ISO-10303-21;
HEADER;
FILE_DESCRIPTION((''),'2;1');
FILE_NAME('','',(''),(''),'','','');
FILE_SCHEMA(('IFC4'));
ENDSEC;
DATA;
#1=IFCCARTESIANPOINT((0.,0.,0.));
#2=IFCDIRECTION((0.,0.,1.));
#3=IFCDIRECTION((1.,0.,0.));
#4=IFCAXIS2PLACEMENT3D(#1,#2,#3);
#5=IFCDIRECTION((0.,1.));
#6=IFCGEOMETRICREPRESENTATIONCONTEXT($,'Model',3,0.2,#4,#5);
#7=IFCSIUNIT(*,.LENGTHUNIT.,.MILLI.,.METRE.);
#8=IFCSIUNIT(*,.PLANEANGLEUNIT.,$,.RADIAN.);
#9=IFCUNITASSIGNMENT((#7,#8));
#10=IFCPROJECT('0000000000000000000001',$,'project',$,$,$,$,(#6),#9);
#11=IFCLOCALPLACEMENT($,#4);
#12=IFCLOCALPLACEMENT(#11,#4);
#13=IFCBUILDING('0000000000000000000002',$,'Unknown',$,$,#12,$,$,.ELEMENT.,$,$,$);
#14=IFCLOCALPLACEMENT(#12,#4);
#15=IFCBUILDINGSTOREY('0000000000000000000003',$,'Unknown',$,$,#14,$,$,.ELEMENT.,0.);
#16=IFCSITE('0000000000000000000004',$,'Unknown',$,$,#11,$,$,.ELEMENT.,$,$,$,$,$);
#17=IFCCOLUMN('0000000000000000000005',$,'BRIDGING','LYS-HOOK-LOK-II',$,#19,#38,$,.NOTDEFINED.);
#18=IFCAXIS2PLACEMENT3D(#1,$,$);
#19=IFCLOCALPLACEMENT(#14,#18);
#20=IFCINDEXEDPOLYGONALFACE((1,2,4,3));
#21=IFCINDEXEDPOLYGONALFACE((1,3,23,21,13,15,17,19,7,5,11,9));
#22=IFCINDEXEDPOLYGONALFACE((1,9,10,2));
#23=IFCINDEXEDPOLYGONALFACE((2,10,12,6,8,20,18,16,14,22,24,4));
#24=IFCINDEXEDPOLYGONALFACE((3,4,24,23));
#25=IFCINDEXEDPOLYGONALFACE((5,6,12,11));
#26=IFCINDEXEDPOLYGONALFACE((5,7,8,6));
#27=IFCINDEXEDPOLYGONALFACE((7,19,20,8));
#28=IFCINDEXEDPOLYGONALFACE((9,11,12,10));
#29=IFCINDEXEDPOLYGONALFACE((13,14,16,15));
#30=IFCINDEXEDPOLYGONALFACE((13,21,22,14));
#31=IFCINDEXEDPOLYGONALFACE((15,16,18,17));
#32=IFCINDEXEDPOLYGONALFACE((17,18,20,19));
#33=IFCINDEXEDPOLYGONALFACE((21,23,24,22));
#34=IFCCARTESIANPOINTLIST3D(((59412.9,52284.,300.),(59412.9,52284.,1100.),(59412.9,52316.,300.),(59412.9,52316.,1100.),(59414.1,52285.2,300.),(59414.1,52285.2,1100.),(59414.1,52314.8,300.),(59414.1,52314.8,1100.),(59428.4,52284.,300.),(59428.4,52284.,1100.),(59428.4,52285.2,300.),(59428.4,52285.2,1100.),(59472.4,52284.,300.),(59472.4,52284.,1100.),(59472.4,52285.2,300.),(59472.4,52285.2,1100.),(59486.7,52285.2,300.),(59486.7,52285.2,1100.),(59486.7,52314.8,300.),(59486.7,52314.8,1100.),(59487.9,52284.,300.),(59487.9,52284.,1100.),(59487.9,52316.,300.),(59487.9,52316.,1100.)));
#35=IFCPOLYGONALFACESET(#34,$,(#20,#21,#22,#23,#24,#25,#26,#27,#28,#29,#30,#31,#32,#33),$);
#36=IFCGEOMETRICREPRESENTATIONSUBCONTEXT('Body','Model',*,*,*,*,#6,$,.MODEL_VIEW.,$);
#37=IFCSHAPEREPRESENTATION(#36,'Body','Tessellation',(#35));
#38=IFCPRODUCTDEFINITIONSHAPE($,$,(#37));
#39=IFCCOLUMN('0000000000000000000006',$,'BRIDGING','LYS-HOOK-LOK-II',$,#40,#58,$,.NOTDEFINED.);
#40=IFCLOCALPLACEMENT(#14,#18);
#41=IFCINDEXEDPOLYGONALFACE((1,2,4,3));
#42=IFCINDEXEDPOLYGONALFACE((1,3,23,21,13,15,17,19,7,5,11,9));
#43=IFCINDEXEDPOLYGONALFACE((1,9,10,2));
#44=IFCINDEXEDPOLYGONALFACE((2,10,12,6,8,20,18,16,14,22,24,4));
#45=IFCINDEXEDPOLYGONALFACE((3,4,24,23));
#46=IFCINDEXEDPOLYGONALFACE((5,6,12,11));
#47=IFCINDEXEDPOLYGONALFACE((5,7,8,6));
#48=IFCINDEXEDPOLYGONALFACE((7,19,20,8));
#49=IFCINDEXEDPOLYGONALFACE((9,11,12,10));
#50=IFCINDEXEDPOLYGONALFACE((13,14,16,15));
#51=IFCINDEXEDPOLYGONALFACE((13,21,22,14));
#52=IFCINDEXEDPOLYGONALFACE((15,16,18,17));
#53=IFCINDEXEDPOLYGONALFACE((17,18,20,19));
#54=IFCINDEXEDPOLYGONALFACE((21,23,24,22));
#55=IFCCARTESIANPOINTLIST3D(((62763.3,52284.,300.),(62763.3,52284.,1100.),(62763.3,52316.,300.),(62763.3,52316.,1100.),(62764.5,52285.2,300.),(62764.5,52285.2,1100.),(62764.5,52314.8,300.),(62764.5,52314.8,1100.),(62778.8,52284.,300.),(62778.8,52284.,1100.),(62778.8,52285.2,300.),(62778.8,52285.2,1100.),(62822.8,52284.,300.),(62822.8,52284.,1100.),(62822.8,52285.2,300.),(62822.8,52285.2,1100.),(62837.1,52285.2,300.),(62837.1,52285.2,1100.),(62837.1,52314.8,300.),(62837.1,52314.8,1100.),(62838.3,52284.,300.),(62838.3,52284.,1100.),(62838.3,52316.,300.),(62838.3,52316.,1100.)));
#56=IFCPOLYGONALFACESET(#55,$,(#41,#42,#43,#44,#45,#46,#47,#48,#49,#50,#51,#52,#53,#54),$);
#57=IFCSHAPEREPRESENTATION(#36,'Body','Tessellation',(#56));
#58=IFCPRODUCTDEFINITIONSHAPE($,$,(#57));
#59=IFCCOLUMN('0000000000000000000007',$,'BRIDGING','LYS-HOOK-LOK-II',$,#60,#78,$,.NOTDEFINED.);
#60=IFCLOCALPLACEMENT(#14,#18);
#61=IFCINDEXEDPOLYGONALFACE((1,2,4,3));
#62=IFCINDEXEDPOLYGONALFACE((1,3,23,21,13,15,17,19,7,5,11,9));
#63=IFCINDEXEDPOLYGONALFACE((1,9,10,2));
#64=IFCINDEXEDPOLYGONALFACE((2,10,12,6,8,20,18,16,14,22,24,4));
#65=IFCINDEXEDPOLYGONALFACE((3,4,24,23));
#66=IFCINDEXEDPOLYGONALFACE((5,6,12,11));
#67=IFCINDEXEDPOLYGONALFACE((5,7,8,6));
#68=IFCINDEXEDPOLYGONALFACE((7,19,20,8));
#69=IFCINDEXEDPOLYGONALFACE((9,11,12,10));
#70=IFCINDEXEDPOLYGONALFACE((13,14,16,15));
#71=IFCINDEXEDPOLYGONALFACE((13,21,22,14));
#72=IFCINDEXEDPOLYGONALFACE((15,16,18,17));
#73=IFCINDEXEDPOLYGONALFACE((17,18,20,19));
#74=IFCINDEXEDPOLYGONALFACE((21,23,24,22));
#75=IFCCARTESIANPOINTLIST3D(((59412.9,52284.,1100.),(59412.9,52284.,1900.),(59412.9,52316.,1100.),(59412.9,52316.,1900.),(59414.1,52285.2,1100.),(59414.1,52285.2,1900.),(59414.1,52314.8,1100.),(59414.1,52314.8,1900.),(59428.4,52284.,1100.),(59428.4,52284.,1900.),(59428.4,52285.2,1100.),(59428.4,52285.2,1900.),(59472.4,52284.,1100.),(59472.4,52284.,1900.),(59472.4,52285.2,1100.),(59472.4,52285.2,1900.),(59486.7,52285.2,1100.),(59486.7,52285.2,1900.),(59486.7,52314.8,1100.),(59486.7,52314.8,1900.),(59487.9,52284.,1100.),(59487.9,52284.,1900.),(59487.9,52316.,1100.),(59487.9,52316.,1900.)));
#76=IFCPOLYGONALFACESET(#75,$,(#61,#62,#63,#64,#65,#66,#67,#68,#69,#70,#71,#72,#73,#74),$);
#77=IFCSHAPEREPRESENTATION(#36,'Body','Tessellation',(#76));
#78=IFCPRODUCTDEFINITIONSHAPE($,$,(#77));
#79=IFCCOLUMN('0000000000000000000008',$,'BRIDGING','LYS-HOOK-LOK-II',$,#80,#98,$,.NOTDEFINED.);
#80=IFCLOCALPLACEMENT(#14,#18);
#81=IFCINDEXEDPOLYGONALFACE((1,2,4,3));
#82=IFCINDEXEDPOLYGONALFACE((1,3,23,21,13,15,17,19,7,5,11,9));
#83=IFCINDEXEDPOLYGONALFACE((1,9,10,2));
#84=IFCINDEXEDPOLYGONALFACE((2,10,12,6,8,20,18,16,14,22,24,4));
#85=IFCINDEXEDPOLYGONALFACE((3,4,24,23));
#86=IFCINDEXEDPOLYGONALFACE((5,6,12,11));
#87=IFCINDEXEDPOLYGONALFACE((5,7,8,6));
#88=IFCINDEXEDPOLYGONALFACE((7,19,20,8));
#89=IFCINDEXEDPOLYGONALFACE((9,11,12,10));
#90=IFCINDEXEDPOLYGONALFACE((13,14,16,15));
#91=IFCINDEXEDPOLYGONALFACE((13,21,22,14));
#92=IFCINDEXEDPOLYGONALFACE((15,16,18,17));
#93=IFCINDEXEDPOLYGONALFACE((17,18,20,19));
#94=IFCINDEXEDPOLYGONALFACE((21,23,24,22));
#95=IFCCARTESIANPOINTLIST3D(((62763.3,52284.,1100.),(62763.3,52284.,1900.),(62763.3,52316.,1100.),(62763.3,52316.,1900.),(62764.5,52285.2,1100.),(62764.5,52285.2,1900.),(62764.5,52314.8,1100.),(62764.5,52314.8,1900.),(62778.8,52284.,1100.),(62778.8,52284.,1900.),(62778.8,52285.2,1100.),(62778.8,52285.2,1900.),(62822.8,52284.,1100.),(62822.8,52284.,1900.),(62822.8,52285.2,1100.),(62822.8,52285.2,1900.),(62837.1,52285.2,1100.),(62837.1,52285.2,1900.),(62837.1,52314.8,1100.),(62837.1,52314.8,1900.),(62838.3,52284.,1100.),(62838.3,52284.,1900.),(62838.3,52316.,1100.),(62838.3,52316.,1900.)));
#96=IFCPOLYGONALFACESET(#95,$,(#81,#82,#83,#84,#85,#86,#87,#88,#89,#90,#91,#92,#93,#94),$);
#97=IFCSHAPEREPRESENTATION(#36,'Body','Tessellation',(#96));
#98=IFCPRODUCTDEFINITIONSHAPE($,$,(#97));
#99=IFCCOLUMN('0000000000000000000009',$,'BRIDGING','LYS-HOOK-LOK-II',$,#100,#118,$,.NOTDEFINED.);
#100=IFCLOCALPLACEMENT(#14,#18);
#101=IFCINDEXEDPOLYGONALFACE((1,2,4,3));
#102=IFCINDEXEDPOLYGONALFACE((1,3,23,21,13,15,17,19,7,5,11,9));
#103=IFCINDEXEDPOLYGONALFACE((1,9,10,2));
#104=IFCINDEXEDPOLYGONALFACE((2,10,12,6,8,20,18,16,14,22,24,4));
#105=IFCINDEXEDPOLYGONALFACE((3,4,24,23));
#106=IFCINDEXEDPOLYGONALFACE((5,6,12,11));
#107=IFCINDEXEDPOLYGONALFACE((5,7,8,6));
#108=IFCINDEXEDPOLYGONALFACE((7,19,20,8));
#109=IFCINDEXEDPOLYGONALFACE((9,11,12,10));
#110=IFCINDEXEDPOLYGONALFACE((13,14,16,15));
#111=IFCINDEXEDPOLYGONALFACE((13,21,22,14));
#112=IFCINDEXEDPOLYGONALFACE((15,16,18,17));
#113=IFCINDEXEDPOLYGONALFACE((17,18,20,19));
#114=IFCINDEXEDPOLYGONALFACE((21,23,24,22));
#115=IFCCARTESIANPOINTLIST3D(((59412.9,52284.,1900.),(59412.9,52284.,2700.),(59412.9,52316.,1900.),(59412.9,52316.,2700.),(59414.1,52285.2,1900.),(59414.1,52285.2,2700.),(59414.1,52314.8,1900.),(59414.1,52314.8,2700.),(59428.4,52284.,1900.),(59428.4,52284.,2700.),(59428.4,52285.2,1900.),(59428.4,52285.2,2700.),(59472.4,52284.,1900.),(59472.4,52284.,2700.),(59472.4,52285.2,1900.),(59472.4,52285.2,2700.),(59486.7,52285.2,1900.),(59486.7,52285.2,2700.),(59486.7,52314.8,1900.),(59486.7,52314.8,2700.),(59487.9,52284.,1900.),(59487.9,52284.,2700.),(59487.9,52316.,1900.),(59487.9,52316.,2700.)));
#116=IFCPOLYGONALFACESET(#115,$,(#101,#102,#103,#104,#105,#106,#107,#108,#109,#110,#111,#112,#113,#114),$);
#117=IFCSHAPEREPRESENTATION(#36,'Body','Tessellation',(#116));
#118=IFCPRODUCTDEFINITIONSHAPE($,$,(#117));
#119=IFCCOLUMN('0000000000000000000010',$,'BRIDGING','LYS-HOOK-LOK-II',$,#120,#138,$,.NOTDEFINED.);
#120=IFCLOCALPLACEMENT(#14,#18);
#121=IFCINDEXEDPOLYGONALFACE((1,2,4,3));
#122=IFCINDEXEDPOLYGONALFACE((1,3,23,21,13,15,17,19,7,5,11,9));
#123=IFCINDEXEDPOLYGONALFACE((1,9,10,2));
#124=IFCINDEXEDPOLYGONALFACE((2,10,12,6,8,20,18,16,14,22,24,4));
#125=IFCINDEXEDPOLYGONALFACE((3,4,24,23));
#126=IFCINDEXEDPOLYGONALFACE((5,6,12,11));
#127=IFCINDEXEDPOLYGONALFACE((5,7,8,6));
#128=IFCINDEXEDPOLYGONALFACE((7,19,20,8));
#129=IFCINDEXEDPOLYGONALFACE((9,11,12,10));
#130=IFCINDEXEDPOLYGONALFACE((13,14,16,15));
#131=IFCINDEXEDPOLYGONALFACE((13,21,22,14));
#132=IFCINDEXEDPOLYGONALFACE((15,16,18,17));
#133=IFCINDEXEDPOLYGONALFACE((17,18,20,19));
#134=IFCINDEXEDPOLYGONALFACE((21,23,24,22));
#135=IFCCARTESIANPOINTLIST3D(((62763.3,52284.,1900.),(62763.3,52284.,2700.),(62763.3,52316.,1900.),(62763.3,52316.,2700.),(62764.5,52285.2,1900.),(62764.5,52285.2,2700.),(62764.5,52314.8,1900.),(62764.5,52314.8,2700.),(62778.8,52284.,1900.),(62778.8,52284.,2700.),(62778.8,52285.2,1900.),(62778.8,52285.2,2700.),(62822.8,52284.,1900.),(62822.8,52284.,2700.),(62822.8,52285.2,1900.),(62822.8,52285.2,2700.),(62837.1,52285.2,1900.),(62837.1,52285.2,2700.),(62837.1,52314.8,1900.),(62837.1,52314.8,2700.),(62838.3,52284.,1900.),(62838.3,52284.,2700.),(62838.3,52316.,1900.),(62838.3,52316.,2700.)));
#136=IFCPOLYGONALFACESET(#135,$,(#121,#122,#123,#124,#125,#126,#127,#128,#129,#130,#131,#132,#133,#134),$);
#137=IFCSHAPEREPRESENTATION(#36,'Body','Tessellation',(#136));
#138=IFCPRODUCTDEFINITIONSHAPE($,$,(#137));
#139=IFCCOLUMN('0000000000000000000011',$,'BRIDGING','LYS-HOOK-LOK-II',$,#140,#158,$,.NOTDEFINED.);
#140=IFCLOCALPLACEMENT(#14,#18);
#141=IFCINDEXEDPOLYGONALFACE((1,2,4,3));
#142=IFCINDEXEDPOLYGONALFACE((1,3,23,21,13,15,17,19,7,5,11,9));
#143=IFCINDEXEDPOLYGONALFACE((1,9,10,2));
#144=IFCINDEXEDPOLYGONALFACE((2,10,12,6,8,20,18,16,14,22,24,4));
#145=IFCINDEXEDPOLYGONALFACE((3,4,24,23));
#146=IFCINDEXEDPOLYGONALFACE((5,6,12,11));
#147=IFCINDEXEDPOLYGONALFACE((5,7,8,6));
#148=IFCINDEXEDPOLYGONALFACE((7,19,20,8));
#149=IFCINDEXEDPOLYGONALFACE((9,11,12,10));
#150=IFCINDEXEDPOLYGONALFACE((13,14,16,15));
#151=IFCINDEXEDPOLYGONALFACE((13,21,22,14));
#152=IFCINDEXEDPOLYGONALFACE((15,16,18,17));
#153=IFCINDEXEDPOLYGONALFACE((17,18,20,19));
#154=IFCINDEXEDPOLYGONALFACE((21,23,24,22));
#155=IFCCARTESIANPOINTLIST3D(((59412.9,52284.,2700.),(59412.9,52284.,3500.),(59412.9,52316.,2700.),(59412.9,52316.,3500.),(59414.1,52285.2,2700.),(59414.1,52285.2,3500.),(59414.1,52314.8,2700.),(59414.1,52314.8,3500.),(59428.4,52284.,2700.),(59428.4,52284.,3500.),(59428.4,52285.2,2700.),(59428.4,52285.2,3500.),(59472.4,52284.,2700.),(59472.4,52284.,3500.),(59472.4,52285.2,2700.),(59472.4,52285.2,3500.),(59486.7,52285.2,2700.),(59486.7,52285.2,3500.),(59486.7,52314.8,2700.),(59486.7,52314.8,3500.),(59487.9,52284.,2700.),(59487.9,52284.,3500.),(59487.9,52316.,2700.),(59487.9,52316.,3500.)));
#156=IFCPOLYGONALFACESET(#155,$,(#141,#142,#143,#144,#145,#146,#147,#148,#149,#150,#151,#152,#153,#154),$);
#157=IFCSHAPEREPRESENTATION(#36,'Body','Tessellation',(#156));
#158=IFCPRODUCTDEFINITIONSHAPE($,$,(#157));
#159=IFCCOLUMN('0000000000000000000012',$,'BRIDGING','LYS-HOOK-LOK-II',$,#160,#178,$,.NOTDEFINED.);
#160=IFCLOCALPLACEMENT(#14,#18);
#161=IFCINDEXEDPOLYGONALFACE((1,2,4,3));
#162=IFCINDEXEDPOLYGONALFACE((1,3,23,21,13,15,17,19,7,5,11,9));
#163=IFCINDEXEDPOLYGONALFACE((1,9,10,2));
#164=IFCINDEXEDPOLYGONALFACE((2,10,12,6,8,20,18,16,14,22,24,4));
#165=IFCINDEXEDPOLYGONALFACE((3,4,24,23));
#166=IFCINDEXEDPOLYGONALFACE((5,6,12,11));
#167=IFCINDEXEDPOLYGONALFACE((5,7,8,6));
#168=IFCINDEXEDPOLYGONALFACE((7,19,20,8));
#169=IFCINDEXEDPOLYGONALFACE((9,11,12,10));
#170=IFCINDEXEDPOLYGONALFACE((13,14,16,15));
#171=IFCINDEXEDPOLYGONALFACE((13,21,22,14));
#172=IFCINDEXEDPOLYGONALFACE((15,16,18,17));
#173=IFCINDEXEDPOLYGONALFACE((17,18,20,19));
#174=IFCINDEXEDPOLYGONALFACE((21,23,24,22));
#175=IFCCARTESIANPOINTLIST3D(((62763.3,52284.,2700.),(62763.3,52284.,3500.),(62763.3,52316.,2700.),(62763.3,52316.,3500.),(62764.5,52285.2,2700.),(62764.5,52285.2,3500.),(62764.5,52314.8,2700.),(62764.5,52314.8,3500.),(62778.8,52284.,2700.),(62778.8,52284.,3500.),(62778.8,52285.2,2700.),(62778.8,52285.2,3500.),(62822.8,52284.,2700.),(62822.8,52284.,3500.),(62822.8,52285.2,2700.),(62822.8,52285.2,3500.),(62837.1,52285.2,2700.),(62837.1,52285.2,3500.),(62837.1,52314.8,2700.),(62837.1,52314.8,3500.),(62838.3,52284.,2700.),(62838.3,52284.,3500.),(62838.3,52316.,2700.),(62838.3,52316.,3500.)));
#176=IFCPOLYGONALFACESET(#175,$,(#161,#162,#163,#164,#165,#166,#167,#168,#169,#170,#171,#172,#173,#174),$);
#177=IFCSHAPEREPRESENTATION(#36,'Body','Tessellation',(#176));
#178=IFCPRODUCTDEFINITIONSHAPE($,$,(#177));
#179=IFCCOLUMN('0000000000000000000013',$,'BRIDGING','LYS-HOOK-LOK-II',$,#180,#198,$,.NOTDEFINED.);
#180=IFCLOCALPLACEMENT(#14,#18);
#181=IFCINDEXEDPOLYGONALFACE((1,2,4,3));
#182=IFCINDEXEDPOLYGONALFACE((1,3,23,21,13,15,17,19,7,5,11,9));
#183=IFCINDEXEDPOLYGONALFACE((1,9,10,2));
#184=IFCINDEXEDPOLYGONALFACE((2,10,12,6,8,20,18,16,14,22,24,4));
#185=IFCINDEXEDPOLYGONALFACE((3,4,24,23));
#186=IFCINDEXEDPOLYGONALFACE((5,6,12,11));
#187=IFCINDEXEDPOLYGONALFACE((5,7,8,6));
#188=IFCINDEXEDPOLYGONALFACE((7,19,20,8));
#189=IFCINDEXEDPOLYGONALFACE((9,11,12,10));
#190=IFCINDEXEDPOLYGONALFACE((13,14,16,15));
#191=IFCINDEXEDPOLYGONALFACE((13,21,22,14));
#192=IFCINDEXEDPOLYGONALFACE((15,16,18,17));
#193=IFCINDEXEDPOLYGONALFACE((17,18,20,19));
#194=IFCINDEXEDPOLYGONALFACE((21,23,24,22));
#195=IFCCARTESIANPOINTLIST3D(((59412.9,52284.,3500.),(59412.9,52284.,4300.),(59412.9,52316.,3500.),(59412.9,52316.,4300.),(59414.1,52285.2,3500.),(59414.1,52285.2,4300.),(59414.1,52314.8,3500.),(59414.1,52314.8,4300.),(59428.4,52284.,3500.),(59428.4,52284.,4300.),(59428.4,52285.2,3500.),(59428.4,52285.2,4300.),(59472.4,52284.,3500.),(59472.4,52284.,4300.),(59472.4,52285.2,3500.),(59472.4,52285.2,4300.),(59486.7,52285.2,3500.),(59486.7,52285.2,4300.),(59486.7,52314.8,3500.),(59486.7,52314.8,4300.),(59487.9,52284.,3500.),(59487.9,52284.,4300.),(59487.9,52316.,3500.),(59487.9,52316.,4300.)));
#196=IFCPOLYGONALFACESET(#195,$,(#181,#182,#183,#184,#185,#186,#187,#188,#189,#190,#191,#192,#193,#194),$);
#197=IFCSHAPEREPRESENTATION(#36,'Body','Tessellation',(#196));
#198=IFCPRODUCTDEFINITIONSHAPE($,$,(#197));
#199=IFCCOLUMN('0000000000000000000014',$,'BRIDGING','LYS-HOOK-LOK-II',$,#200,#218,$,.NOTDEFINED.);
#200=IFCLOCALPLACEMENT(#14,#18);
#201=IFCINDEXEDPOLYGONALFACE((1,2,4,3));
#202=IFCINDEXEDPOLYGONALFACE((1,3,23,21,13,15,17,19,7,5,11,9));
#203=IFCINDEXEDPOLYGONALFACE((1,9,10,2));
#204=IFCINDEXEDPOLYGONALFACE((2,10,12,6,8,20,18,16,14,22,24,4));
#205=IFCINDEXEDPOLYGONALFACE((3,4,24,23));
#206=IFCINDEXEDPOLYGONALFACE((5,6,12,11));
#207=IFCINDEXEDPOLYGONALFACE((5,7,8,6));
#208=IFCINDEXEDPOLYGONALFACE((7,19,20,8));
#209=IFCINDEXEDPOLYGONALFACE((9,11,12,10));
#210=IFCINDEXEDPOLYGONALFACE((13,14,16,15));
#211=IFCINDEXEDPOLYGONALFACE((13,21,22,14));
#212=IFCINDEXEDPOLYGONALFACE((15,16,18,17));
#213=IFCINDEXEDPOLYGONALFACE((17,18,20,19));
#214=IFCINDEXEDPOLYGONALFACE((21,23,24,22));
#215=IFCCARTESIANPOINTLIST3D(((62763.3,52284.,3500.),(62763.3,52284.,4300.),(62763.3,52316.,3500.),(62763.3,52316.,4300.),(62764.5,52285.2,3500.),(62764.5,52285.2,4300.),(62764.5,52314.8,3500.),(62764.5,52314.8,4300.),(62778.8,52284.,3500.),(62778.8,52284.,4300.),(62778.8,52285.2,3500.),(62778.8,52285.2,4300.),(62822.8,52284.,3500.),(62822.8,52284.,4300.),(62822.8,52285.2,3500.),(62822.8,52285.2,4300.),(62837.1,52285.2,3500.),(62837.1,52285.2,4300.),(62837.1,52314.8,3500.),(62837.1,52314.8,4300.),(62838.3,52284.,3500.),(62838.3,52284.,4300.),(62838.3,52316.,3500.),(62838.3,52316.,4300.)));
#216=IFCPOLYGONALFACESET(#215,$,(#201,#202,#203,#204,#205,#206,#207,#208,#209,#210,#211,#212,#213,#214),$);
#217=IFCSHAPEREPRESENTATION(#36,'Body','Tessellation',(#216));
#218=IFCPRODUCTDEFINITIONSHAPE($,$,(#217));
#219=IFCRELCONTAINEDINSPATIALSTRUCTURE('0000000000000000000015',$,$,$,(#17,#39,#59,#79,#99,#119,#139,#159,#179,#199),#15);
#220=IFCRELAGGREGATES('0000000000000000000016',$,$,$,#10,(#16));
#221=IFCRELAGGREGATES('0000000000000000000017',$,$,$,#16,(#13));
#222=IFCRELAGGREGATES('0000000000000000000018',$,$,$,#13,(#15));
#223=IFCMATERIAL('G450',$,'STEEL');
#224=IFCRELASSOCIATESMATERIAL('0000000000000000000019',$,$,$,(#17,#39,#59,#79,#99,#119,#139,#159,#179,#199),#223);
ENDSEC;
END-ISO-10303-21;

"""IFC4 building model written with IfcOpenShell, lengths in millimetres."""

from ifc_helpers import new_model, si_unit, direction, frame, origin_with_axes, place, context, subcontext, project, spatial, line, indexed_curve, outline, extrude, material, element, save


model = new_model("IFC4")

# Units and contexts
model_context = context("Model", 3, precision=0.2, world=origin_with_axes(), true_north=direction((0.0, 1.0)))
body_context = subcontext(model_context, "Body", "Model", "MODEL_VIEW")
ifc_project = project(units=[si_unit("LENGTHUNIT", "METRE", prefix="MILLI"), si_unit("PLANEANGLEUNIT", "RADIAN")], contexts=[model_context])

# Site, building, storey
site_placement = place(None, origin_with_axes())
site = spatial("IfcSite", under=ifc_project, at=site_placement, Name="Unknown", CompositionType="ELEMENT")
building_placement = place(site_placement, origin_with_axes())
building = spatial("IfcBuilding", under=site, at=building_placement, Name="Unknown", CompositionType="ELEMENT")
storey_placement = place(building_placement, origin_with_axes())
storey = spatial("IfcBuildingStorey", under=building, at=storey_placement, Name="Unknown", CompositionType="ELEMENT", Elevation=0.0)

# Columns
ifc_material = material(Name="G450", Category="STEEL")
for number, where, z_axis, x_axis, name in (
    (1, (59450.4, 52300.0, 300.0), (0.0, -1.0, 0.0), (0.0, 0.0, 1.0), "BRIDGING"),
    (2, (62800.8, 52300.0, 300.0), (0.0, -1.0, 0.0), (0.0, 0.0, 1.0), "BRIDGING"),
    (3, (59450.4, 52300.0, 1100.0), (0.0, -1.0, 0.0), (0.0, 0.0, 1.0), "BRIDGING"),
    (4, (62800.8, 52300.0, 1100.0), (0.0, -1.0, 0.0), (0.0, 0.0, 1.0), "BRIDGING"),
    (5, (59450.4, 52300.0, 1900.0), (0.0, -1.0, 0.0), (0.0, 0.0, 1.0), "BRIDGING"),
    (6, (62800.8, 52300.0, 1900.0), (0.0, -1.0, 0.0), (0.0, 0.0, 1.0), "BRIDGING"),
    (7, (59450.4, 52300.0, 2700.0), (0.0, -1.0, 0.0), (0.0, 0.0, 1.0), "BRIDGING"),
    (8, (62800.8, 52300.0, 2700.0), (0.0, -1.0, 0.0), (0.0, 0.0, 1.0), "BRIDGING"),
    (9, (59450.4, 52300.0, 3500.0), (0.0, -1.0, 0.0), (0.0, 0.0, 1.0), "BRIDGING"),
    (10, (62800.8, 52300.0, 3500.0), (0.0, -1.0, 0.0), (0.0, 0.0, 1.0), "BRIDGING"),
):
    element("IfcColumn", number, at=place(storey_placement, frame(where, z_axis=z_axis, x_axis=x_axis)), inside=storey, material=ifc_material, Name=name, Description="LYS-HOOK-LOK-II", PredefinedType="NOTDEFINED", context=body_context, shape_type="SolidModel", body=[
        extrude(outline(indexed_curve([(16.0, -37.5), (16.0, -22.0), (14.8, -22.0), (14.8, -36.3), (-14.8, -36.3), (-14.8, 36.3), (14.8, 36.3), (14.8, 22.0), (16.0, 22.0), (16.0, 37.5), (-16.0, 37.5), (-16.0, -37.5)], segments=[line(1, 2, 3, 4, 5, 6, 7, 8, 9, 10, 11, 12, 1)])), frame((0.0, 0.0, 0.0), z_axis=(-1.0, 0.0, 0.0), x_axis=(0.0, 0.0, 1.0)), (0.0, 0.0, -1.0), 800.0),
    ])

save(model, "model.ifc")
